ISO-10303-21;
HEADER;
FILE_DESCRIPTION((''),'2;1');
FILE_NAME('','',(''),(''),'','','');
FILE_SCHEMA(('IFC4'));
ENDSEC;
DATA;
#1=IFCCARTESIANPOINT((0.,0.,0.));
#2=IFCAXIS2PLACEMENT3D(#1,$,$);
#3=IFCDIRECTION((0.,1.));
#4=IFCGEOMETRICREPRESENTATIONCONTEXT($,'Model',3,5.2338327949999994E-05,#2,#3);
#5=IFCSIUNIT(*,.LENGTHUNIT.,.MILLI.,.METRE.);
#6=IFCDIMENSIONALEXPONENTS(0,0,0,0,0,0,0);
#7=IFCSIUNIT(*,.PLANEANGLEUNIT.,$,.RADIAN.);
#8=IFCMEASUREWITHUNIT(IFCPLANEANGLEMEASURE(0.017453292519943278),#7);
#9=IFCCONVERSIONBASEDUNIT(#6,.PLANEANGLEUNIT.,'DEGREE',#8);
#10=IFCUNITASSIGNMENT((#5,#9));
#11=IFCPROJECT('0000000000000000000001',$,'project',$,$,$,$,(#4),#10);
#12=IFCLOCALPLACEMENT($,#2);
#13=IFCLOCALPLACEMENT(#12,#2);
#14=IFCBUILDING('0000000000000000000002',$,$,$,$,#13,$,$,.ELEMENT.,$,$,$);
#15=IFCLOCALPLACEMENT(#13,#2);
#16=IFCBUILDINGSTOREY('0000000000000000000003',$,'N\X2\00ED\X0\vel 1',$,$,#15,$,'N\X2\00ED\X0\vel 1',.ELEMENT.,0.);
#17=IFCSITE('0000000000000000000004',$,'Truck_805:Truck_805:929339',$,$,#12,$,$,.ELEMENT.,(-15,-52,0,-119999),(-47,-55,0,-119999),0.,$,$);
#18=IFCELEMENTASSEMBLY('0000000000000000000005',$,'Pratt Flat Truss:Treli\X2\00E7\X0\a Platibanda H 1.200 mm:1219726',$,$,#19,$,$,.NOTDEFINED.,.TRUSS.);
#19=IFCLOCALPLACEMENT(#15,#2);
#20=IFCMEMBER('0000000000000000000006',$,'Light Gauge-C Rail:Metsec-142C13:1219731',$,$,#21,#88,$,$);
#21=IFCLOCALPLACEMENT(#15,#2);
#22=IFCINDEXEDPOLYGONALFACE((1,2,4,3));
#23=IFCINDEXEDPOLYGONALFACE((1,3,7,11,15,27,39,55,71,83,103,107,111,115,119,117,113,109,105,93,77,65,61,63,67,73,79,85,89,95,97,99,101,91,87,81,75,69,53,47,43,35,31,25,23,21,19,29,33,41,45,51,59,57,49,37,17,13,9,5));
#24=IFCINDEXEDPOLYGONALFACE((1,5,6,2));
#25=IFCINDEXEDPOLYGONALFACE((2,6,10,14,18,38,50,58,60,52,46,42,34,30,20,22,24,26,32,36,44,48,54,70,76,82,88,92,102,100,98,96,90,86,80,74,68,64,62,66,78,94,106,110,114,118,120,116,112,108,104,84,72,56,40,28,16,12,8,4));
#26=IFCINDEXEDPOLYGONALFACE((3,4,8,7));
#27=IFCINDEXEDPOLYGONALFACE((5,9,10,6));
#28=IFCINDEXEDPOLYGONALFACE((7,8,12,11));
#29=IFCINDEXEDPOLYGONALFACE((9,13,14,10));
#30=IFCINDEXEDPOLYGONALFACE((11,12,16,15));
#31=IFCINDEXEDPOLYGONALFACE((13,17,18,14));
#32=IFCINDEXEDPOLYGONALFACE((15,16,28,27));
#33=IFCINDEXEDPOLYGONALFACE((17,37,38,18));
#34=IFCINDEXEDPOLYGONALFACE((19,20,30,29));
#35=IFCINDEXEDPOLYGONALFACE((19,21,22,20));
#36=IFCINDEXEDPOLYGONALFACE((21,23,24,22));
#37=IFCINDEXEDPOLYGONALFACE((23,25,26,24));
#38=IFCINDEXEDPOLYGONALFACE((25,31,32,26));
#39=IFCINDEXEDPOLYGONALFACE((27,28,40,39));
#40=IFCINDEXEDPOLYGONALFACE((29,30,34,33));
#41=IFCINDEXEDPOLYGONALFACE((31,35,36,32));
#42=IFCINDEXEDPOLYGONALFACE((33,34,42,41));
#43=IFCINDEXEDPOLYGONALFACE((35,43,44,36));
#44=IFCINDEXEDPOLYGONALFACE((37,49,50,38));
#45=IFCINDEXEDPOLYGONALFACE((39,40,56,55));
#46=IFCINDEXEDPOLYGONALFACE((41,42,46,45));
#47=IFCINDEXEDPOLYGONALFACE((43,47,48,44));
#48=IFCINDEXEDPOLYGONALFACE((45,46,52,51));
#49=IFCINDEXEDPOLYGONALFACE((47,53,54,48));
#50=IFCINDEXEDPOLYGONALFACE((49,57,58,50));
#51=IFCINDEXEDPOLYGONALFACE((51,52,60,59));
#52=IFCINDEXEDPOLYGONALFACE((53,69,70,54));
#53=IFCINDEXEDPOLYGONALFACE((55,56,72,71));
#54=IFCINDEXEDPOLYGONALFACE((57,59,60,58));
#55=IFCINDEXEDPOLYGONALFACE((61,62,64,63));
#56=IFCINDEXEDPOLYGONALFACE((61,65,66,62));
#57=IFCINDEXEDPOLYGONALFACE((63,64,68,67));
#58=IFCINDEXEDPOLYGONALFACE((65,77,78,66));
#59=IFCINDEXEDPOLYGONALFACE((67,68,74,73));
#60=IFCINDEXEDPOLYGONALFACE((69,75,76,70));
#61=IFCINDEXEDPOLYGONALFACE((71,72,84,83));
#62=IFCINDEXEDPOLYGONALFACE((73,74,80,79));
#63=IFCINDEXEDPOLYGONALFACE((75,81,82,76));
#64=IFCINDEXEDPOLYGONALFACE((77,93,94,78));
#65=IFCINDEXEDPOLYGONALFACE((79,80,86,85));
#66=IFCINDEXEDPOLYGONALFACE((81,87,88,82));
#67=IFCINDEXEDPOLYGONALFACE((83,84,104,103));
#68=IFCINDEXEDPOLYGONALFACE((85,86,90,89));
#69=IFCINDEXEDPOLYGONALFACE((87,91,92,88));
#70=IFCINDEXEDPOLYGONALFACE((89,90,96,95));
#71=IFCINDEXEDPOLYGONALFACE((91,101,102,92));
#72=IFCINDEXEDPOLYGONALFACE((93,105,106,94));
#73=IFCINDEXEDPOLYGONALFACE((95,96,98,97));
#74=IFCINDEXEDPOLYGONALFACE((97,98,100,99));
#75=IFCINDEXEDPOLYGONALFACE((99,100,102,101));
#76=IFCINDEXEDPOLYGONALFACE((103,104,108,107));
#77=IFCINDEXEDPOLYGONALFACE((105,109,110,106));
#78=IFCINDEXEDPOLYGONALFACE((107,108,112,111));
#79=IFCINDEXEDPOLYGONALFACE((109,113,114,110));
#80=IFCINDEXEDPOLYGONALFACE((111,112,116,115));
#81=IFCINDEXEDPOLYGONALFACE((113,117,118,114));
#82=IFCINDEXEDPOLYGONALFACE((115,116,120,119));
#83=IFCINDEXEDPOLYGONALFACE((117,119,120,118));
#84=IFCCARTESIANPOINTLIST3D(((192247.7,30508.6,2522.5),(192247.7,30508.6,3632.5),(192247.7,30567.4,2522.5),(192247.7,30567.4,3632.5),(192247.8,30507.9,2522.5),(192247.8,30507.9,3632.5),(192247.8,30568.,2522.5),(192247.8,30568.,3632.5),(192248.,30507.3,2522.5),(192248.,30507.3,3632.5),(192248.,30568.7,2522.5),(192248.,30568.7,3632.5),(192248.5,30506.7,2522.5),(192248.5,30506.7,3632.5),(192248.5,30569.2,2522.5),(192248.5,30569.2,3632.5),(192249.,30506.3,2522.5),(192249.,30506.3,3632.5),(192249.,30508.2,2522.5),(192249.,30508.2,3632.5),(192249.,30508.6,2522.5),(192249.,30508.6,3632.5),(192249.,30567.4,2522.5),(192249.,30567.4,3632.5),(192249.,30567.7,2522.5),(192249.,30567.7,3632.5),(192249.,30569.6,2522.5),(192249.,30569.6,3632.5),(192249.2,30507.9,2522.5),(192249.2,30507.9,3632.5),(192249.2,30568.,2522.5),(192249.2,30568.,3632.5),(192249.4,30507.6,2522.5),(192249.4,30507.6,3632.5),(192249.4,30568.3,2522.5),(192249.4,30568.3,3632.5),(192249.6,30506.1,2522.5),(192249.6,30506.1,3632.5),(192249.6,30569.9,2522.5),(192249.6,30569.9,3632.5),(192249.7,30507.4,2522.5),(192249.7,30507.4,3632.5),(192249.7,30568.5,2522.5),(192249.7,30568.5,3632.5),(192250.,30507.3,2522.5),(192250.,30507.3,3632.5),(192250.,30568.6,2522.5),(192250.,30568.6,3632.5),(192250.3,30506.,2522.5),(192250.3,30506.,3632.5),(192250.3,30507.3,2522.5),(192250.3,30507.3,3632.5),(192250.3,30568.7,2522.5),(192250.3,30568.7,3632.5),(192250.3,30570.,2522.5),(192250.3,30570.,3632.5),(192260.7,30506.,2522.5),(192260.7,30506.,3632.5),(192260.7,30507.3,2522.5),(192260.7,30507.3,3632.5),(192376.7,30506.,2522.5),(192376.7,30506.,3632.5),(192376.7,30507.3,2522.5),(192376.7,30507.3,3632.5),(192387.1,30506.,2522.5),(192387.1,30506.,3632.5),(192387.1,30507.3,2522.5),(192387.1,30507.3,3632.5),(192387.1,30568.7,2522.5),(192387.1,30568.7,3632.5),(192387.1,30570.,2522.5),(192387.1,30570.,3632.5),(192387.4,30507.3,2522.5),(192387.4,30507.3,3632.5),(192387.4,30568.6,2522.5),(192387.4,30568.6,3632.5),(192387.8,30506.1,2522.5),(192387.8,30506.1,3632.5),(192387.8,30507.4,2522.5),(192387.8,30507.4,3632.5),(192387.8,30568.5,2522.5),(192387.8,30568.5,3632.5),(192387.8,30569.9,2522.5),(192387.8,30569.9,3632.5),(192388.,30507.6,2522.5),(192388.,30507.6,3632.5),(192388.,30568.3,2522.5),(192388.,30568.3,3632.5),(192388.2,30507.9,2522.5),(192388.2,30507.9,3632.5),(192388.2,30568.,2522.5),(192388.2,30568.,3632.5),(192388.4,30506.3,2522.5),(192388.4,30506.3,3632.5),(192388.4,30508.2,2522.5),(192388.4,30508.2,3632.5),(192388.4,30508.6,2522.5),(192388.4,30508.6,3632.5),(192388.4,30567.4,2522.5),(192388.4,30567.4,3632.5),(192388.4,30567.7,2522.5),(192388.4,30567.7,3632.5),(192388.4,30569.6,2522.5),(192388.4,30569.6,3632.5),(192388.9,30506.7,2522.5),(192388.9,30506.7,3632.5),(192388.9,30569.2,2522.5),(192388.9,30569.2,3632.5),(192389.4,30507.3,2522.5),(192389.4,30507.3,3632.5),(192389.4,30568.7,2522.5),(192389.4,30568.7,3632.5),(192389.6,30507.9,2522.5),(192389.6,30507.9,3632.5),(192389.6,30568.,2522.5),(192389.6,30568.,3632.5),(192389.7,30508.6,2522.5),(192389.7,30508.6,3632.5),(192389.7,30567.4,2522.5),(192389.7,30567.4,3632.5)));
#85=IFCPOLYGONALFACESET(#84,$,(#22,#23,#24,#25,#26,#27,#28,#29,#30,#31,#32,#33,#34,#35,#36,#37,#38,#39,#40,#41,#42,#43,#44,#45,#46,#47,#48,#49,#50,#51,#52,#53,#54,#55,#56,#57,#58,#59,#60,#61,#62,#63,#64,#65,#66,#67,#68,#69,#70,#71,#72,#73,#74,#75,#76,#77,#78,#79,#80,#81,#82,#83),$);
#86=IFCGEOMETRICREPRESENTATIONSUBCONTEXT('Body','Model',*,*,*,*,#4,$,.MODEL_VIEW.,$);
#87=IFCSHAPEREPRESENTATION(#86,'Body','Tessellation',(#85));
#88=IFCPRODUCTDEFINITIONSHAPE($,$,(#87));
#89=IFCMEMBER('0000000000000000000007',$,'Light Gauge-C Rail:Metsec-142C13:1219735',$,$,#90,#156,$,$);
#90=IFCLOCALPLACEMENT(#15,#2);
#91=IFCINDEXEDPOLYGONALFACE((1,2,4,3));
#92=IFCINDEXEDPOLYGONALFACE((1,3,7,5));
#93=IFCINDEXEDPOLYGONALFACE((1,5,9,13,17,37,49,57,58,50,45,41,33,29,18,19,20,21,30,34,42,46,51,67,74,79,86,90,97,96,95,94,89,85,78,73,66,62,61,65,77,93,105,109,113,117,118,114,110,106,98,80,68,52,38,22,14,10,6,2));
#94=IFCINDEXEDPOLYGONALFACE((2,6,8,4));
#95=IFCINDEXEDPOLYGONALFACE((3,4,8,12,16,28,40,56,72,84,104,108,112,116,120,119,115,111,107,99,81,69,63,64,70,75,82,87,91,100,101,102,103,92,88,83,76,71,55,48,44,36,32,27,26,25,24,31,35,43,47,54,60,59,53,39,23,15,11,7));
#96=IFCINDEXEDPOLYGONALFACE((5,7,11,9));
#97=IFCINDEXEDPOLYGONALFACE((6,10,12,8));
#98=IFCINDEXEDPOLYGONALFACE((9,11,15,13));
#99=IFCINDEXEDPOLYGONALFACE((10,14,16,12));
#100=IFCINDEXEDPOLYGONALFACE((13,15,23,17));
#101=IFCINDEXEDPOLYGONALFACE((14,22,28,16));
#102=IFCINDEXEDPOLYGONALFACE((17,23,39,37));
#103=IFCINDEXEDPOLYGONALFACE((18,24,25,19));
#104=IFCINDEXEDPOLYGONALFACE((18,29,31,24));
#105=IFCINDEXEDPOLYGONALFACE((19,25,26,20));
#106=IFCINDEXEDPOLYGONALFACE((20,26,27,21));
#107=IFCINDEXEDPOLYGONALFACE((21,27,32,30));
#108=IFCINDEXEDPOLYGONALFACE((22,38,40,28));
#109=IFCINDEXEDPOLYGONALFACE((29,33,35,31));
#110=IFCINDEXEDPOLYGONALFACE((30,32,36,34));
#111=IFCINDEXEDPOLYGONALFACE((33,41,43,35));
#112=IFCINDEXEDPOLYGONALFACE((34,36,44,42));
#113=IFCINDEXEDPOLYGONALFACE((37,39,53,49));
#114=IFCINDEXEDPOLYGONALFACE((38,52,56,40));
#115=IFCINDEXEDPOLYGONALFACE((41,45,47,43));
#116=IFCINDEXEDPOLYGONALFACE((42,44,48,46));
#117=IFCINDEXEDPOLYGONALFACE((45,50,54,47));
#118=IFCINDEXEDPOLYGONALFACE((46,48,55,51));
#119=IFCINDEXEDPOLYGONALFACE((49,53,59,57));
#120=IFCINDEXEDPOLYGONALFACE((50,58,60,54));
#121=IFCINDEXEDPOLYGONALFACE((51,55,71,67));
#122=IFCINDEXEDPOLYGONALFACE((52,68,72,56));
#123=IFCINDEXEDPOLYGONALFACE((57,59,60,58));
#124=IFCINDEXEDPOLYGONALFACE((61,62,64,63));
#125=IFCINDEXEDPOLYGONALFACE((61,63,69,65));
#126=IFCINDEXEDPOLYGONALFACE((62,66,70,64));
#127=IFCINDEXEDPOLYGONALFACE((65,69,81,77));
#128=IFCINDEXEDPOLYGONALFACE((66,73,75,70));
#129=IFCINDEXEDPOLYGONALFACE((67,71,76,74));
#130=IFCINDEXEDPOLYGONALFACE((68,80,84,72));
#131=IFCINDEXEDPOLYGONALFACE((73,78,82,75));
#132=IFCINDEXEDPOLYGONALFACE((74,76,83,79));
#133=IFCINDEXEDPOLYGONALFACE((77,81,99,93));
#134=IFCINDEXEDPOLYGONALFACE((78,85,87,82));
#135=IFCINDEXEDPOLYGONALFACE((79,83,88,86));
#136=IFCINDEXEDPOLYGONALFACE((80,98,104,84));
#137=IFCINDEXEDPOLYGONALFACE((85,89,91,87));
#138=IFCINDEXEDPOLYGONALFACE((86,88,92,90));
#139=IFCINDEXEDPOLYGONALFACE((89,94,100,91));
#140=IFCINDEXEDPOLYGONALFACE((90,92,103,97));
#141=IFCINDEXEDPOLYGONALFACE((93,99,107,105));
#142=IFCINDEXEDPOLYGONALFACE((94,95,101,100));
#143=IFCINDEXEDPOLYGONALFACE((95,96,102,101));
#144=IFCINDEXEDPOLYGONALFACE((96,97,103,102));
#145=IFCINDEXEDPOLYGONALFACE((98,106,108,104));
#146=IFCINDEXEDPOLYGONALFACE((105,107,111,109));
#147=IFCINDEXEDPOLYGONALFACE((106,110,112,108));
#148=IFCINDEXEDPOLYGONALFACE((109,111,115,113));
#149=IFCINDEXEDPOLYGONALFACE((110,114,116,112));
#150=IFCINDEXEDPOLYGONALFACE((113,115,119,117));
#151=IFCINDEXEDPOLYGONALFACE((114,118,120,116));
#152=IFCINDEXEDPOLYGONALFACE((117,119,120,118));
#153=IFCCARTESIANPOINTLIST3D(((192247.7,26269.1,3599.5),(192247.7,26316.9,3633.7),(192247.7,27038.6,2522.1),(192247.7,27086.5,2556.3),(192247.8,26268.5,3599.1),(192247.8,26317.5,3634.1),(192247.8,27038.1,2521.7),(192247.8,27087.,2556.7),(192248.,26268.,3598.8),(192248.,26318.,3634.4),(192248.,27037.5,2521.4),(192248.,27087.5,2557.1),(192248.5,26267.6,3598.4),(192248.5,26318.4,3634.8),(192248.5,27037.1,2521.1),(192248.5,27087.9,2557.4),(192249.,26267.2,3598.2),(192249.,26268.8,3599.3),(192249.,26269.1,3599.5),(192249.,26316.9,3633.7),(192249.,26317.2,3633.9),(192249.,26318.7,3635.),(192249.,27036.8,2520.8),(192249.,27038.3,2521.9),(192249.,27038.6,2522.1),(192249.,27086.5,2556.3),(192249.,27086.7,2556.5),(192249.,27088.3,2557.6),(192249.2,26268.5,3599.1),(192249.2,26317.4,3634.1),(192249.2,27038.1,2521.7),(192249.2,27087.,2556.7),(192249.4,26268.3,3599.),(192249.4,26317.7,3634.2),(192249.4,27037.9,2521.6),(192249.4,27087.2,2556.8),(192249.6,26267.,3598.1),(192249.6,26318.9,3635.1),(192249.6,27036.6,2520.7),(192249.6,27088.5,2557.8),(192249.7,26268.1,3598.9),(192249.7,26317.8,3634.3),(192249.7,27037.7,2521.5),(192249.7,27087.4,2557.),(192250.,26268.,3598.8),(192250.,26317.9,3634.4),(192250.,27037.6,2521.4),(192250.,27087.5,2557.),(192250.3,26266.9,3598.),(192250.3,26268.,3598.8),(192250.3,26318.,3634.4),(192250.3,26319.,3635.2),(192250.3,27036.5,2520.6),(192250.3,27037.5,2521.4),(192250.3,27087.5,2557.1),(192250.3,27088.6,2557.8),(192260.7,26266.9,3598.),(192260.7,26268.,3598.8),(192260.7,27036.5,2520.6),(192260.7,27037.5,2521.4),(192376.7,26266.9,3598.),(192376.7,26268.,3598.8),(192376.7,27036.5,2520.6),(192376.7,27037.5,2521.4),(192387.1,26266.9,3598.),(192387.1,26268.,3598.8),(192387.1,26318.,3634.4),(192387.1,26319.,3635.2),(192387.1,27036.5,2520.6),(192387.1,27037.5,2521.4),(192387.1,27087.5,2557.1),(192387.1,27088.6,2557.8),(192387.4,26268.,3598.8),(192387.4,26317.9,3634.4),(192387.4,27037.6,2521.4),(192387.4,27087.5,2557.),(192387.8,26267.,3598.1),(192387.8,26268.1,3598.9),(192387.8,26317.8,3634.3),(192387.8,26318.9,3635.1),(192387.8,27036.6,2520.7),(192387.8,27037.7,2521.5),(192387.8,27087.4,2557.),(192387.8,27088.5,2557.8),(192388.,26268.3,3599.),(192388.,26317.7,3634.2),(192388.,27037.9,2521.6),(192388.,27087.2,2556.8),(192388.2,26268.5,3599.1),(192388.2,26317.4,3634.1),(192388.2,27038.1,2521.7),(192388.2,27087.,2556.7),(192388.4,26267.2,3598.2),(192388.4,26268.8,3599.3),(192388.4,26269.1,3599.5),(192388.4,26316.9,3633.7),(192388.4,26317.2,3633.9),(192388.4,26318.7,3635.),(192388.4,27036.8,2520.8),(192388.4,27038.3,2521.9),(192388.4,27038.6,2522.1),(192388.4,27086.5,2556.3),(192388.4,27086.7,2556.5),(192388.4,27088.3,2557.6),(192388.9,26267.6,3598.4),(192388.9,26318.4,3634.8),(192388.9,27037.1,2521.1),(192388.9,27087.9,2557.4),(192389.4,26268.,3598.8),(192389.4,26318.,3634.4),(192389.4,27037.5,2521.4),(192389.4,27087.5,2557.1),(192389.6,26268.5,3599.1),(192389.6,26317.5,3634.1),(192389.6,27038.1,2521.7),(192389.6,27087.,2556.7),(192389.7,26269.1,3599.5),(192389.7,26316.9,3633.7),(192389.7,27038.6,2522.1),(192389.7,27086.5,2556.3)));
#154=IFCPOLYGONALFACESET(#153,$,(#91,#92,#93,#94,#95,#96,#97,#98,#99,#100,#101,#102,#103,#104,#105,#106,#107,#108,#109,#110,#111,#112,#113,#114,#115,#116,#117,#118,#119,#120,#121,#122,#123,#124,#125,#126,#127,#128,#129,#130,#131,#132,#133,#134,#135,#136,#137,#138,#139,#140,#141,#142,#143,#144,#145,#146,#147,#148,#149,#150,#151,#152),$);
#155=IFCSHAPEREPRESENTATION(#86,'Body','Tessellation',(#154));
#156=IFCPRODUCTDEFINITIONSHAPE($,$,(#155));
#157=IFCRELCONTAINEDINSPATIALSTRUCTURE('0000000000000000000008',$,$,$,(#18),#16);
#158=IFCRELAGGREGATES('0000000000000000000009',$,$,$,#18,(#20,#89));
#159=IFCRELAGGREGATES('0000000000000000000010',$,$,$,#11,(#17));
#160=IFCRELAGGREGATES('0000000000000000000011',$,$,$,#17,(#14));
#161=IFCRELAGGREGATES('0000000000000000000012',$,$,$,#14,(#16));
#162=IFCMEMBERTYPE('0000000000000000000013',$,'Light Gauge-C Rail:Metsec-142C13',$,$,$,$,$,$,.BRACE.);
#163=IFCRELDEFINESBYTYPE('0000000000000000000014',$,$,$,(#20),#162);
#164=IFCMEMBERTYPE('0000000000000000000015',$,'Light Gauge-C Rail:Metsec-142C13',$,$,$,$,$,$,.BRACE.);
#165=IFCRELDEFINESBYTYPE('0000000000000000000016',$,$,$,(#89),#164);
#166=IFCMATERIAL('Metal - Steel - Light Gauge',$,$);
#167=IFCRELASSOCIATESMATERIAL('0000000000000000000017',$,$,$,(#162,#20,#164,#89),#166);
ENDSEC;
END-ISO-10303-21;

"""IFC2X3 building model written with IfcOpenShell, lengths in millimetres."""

from ifc_helpers import new_model, entity, si_unit, converted_unit, direction, frame, frame_2d, origin, place, context, subcontext, project, spatial, polyline, circle_curve, parameter, trimmed, segment, composite_curve, outline, extrude, source, transform, mapped, material, type_object, type_shapes, element, aggregate, save


model = new_model("IFC2X3")

# Units and contexts
model_context = context("Model", 3, precision=5.2338327949999994e-05, world=origin(), true_north=direction((0.0, 1.0)))
body_context = subcontext(model_context, "Body", "Model", "MODEL_VIEW")
ifc_project = project(units=[si_unit("LENGTHUNIT", "METRE", prefix="MILLI"), converted_unit("PLANEANGLEUNIT", "DEGREE", entity("IfcPlaneAngleMeasure", 0.017453292519943278), si_unit("PLANEANGLEUNIT", "RADIAN"), dimensions=[0, 0, 0, 0, 0, 0, 0])], contexts=[model_context])

# Site, building, storey
site_placement = place(None, origin())
site = spatial("IfcSite", under=ifc_project, at=site_placement, Name="Truck_805:Truck_805:929339", CompositionType="ELEMENT", RefLatitude=(-15, -52, 0, -119999), RefLongitude=(-47, -55, 0, -119999), RefElevation=0.0)
building_placement = place(site_placement, origin())
building = spatial("IfcBuilding", under=site, at=building_placement, CompositionType="ELEMENT")
storey_placement = place(building_placement, origin())
storey = spatial("IfcBuildingStorey", under=building, at=storey_placement, Name="Nível 1", LongName="Nível 1", CompositionType="ELEMENT", Elevation=0.0)

# Element assembly, members
assembly_1_placement = place(storey_placement, origin())
assembly_1 = element("IfcElementAssembly", 1, at=assembly_1_placement, inside=storey, Name="Pratt Flat Truss:Treliça Platibanda H 1.200 mm:1219726", AssemblyPlace="NOTDEFINED", PredefinedType="TRUSS")
ifc_material_1 = material(Name="Metal - Steel - Light Gauge")
member_type_1 = type_object("IfcMemberType", Name="Light Gauge-C Rail:Metsec-142C13", PredefinedType="BRACE", material=ifc_material_1)
shared_shape_1 = source(origin(), body_context, "Body", "SweptSolid", [
    extrude(outline(composite_curve([segment(polyline([(-23.1, -71.0), (35.7, -71.0)]), True, "CONTINUOUS"), segment(trimmed(circle_curve(frame_2d((35.7, -68.4), x_axis=(0.0, -1.0)), 2.6), [parameter(0.0)], [parameter(90.0)], True, "PARAMETER"), True, "CONTINUOUS"), segment(polyline([(38.3, -68.4), (38.3, 68.4)]), True, "CONTINUOUS"), segment(trimmed(circle_curve(frame_2d((35.7, 68.4), x_axis=(1.0, 0.0)), 2.6), [parameter(0.0)], [parameter(90.0)], True, "PARAMETER"), True, "CONTINUOUS"), segment(polyline([(35.7, 71.0), (-23.1, 71.0)]), True, "CONTINUOUS"), segment(trimmed(circle_curve(frame_2d((-23.1, 68.4), x_axis=(0.0, 1.0)), 2.6), [parameter(0.0)], [parameter(90.0)], True, "PARAMETER"), True, "CONTINUOUS"), segment(polyline([(-25.7, 68.4), (-25.7, 58.0)]), True, "CONTINUOUS"), segment(polyline([(-25.7, 58.0), (-24.4, 58.0)]), True, "CONTINUOUS"), segment(polyline([(-24.4, 58.0), (-24.4, 68.4)]), True, "CONTINUOUS"), segment(trimmed(circle_curve(frame_2d((-23.1, 68.4), x_axis=(-1.0, 0.0)), 1.3), [parameter(270.0)], [parameter(0.0)], True, "PARAMETER"), False, "CONTINUOUS"), segment(polyline([(-23.1, 69.7), (35.7, 69.7)]), True, "CONTINUOUS"), segment(trimmed(circle_curve(frame_2d((35.7, 68.4), x_axis=(0.0, 1.0)), 1.3), [parameter(270.0)], [parameter(0.0)], True, "PARAMETER"), False, "CONTINUOUS"), segment(polyline([(37.0, 68.4), (37.0, -68.4)]), True, "CONTINUOUS"), segment(trimmed(circle_curve(frame_2d((35.7, -68.4), x_axis=(1.0, 0.0)), 1.3), [parameter(270.0)], [parameter(0.0)], True, "PARAMETER"), False, "CONTINUOUS"), segment(polyline([(35.7, -69.7), (-23.1, -69.7)]), True, "CONTINUOUS"), segment(trimmed(circle_curve(frame_2d((-23.1, -68.4), x_axis=(0.0, -1.0)), 1.3), [parameter(270.0)], [parameter(0.0)], True, "PARAMETER"), False, "CONTINUOUS"), segment(polyline([(-24.4, -68.4), (-24.4, -58.0)]), True, "CONTINUOUS"), segment(polyline([(-24.4, -58.0), (-25.7, -58.0)]), True, "CONTINUOUS"), segment(polyline([(-25.7, -58.0), (-25.7, -68.4)]), True, "CONTINUOUS"), segment(trimmed(circle_curve(frame_2d((-23.1, -68.4), x_axis=(-1.0, 0.0)), 2.6), [parameter(0.0)], [parameter(90.0)], True, "PARAMETER"), True, "CONTINUOUS")], self_intersect=False)), frame((-555.0, 0.0, 18.8), z_axis=(1.0, 0.0, 0.0), x_axis=(0.0, 0.0, -1.0)), (0.0, 0.0, 1.0), 1110.0),
])
type_shapes(member_type_1, [shared_shape_1])
member_1_placement = place(assembly_1_placement, frame((192318.7, 30550.5, 3077.5), z_axis=(0.0, -1.0, 0.0), x_axis=(0.0, 0.0, 1.0)))
member_1 = element("IfcMember", 2, at=member_1_placement, type_object=member_type_1, material=ifc_material_1, Name="Light Gauge-C Rail:Metsec-142C13:1219731", context=body_context, shape_type="MappedRepresentation", body=[
    mapped(shared_shape_1, transform((0.0, 0.0, 0.0), scale=1.0)),
])
member_type_2 = type_object("IfcMemberType", Name="Light Gauge-C Rail:Metsec-142C13", PredefinedType="BRACE", material=ifc_material_1)
shared_shape_2 = source(origin(), body_context, "Body", "SweptSolid", [
    extrude(outline(composite_curve([segment(polyline([(-23.1, -71.0), (35.7, -71.0)]), True, "CONTINUOUS"), segment(trimmed(circle_curve(frame_2d((35.7, -68.4), x_axis=(0.0, -1.0)), 2.6), [parameter(0.0)], [parameter(90.0)], True, "PARAMETER"), True, "CONTINUOUS"), segment(polyline([(38.3, -68.4), (38.3, 68.4)]), True, "CONTINUOUS"), segment(trimmed(circle_curve(frame_2d((35.7, 68.4), x_axis=(1.0, 0.0)), 2.6), [parameter(0.0)], [parameter(90.0)], True, "PARAMETER"), True, "CONTINUOUS"), segment(polyline([(35.7, 71.0), (-23.1, 71.0)]), True, "CONTINUOUS"), segment(trimmed(circle_curve(frame_2d((-23.1, 68.4), x_axis=(0.0, 1.0)), 2.6), [parameter(0.0)], [parameter(90.0)], True, "PARAMETER"), True, "CONTINUOUS"), segment(polyline([(-25.7, 68.4), (-25.7, 58.0)]), True, "CONTINUOUS"), segment(polyline([(-25.7, 58.0), (-24.4, 58.0)]), True, "CONTINUOUS"), segment(polyline([(-24.4, 58.0), (-24.4, 68.4)]), True, "CONTINUOUS"), segment(trimmed(circle_curve(frame_2d((-23.1, 68.4), x_axis=(-1.0, 0.0)), 1.3), [parameter(270.0)], [parameter(0.0)], True, "PARAMETER"), False, "CONTINUOUS"), segment(polyline([(-23.1, 69.7), (35.7, 69.7)]), True, "CONTINUOUS"), segment(trimmed(circle_curve(frame_2d((35.7, 68.4), x_axis=(0.0, 1.0)), 1.3), [parameter(270.0)], [parameter(0.0)], True, "PARAMETER"), False, "CONTINUOUS"), segment(polyline([(37.0, 68.4), (37.0, -68.4)]), True, "CONTINUOUS"), segment(trimmed(circle_curve(frame_2d((35.7, -68.4), x_axis=(1.0, 0.0)), 1.3), [parameter(270.0)], [parameter(0.0)], True, "PARAMETER"), False, "CONTINUOUS"), segment(polyline([(35.7, -69.7), (-23.1, -69.7)]), True, "CONTINUOUS"), segment(trimmed(circle_curve(frame_2d((-23.1, -68.4), x_axis=(0.0, -1.0)), 1.3), [parameter(270.0)], [parameter(0.0)], True, "PARAMETER"), False, "CONTINUOUS"), segment(polyline([(-24.4, -68.4), (-24.4, -58.0)]), True, "CONTINUOUS"), segment(polyline([(-24.4, -58.0), (-25.7, -58.0)]), True, "CONTINUOUS"), segment(polyline([(-25.7, -58.0), (-25.7, -68.4)]), True, "CONTINUOUS"), segment(trimmed(circle_curve(frame_2d((-23.1, -68.4), x_axis=(-1.0, 0.0)), 2.6), [parameter(0.0)], [parameter(90.0)], True, "PARAMETER"), True, "CONTINUOUS")], self_intersect=False)), frame((-653.0, 0.0, 18.8), z_axis=(1.0, 0.0, 0.0), x_axis=(0.0, 0.0, -1.0)), (0.0, 0.0, 1.0), 1324.0),
])
type_shapes(member_type_2, [shared_shape_2])
member_2_placement = place(assembly_1_placement, frame((192318.7, 26693.2, 3077.8), z_axis=(0.0, -0.813738, -0.581231), x_axis=(0.0, -0.581231, 0.813738)))
member_2 = element("IfcMember", 3, at=member_2_placement, type_object=member_type_2, material=ifc_material_1, Name="Light Gauge-C Rail:Metsec-142C13:1219735", context=body_context, shape_type="MappedRepresentation", body=[
    mapped(shared_shape_2, transform((0.0, 0.0, 0.0), scale=1.0)),
])
aggregate(assembly_1, [member_1, member_2])

save(model, "model.ifc")
